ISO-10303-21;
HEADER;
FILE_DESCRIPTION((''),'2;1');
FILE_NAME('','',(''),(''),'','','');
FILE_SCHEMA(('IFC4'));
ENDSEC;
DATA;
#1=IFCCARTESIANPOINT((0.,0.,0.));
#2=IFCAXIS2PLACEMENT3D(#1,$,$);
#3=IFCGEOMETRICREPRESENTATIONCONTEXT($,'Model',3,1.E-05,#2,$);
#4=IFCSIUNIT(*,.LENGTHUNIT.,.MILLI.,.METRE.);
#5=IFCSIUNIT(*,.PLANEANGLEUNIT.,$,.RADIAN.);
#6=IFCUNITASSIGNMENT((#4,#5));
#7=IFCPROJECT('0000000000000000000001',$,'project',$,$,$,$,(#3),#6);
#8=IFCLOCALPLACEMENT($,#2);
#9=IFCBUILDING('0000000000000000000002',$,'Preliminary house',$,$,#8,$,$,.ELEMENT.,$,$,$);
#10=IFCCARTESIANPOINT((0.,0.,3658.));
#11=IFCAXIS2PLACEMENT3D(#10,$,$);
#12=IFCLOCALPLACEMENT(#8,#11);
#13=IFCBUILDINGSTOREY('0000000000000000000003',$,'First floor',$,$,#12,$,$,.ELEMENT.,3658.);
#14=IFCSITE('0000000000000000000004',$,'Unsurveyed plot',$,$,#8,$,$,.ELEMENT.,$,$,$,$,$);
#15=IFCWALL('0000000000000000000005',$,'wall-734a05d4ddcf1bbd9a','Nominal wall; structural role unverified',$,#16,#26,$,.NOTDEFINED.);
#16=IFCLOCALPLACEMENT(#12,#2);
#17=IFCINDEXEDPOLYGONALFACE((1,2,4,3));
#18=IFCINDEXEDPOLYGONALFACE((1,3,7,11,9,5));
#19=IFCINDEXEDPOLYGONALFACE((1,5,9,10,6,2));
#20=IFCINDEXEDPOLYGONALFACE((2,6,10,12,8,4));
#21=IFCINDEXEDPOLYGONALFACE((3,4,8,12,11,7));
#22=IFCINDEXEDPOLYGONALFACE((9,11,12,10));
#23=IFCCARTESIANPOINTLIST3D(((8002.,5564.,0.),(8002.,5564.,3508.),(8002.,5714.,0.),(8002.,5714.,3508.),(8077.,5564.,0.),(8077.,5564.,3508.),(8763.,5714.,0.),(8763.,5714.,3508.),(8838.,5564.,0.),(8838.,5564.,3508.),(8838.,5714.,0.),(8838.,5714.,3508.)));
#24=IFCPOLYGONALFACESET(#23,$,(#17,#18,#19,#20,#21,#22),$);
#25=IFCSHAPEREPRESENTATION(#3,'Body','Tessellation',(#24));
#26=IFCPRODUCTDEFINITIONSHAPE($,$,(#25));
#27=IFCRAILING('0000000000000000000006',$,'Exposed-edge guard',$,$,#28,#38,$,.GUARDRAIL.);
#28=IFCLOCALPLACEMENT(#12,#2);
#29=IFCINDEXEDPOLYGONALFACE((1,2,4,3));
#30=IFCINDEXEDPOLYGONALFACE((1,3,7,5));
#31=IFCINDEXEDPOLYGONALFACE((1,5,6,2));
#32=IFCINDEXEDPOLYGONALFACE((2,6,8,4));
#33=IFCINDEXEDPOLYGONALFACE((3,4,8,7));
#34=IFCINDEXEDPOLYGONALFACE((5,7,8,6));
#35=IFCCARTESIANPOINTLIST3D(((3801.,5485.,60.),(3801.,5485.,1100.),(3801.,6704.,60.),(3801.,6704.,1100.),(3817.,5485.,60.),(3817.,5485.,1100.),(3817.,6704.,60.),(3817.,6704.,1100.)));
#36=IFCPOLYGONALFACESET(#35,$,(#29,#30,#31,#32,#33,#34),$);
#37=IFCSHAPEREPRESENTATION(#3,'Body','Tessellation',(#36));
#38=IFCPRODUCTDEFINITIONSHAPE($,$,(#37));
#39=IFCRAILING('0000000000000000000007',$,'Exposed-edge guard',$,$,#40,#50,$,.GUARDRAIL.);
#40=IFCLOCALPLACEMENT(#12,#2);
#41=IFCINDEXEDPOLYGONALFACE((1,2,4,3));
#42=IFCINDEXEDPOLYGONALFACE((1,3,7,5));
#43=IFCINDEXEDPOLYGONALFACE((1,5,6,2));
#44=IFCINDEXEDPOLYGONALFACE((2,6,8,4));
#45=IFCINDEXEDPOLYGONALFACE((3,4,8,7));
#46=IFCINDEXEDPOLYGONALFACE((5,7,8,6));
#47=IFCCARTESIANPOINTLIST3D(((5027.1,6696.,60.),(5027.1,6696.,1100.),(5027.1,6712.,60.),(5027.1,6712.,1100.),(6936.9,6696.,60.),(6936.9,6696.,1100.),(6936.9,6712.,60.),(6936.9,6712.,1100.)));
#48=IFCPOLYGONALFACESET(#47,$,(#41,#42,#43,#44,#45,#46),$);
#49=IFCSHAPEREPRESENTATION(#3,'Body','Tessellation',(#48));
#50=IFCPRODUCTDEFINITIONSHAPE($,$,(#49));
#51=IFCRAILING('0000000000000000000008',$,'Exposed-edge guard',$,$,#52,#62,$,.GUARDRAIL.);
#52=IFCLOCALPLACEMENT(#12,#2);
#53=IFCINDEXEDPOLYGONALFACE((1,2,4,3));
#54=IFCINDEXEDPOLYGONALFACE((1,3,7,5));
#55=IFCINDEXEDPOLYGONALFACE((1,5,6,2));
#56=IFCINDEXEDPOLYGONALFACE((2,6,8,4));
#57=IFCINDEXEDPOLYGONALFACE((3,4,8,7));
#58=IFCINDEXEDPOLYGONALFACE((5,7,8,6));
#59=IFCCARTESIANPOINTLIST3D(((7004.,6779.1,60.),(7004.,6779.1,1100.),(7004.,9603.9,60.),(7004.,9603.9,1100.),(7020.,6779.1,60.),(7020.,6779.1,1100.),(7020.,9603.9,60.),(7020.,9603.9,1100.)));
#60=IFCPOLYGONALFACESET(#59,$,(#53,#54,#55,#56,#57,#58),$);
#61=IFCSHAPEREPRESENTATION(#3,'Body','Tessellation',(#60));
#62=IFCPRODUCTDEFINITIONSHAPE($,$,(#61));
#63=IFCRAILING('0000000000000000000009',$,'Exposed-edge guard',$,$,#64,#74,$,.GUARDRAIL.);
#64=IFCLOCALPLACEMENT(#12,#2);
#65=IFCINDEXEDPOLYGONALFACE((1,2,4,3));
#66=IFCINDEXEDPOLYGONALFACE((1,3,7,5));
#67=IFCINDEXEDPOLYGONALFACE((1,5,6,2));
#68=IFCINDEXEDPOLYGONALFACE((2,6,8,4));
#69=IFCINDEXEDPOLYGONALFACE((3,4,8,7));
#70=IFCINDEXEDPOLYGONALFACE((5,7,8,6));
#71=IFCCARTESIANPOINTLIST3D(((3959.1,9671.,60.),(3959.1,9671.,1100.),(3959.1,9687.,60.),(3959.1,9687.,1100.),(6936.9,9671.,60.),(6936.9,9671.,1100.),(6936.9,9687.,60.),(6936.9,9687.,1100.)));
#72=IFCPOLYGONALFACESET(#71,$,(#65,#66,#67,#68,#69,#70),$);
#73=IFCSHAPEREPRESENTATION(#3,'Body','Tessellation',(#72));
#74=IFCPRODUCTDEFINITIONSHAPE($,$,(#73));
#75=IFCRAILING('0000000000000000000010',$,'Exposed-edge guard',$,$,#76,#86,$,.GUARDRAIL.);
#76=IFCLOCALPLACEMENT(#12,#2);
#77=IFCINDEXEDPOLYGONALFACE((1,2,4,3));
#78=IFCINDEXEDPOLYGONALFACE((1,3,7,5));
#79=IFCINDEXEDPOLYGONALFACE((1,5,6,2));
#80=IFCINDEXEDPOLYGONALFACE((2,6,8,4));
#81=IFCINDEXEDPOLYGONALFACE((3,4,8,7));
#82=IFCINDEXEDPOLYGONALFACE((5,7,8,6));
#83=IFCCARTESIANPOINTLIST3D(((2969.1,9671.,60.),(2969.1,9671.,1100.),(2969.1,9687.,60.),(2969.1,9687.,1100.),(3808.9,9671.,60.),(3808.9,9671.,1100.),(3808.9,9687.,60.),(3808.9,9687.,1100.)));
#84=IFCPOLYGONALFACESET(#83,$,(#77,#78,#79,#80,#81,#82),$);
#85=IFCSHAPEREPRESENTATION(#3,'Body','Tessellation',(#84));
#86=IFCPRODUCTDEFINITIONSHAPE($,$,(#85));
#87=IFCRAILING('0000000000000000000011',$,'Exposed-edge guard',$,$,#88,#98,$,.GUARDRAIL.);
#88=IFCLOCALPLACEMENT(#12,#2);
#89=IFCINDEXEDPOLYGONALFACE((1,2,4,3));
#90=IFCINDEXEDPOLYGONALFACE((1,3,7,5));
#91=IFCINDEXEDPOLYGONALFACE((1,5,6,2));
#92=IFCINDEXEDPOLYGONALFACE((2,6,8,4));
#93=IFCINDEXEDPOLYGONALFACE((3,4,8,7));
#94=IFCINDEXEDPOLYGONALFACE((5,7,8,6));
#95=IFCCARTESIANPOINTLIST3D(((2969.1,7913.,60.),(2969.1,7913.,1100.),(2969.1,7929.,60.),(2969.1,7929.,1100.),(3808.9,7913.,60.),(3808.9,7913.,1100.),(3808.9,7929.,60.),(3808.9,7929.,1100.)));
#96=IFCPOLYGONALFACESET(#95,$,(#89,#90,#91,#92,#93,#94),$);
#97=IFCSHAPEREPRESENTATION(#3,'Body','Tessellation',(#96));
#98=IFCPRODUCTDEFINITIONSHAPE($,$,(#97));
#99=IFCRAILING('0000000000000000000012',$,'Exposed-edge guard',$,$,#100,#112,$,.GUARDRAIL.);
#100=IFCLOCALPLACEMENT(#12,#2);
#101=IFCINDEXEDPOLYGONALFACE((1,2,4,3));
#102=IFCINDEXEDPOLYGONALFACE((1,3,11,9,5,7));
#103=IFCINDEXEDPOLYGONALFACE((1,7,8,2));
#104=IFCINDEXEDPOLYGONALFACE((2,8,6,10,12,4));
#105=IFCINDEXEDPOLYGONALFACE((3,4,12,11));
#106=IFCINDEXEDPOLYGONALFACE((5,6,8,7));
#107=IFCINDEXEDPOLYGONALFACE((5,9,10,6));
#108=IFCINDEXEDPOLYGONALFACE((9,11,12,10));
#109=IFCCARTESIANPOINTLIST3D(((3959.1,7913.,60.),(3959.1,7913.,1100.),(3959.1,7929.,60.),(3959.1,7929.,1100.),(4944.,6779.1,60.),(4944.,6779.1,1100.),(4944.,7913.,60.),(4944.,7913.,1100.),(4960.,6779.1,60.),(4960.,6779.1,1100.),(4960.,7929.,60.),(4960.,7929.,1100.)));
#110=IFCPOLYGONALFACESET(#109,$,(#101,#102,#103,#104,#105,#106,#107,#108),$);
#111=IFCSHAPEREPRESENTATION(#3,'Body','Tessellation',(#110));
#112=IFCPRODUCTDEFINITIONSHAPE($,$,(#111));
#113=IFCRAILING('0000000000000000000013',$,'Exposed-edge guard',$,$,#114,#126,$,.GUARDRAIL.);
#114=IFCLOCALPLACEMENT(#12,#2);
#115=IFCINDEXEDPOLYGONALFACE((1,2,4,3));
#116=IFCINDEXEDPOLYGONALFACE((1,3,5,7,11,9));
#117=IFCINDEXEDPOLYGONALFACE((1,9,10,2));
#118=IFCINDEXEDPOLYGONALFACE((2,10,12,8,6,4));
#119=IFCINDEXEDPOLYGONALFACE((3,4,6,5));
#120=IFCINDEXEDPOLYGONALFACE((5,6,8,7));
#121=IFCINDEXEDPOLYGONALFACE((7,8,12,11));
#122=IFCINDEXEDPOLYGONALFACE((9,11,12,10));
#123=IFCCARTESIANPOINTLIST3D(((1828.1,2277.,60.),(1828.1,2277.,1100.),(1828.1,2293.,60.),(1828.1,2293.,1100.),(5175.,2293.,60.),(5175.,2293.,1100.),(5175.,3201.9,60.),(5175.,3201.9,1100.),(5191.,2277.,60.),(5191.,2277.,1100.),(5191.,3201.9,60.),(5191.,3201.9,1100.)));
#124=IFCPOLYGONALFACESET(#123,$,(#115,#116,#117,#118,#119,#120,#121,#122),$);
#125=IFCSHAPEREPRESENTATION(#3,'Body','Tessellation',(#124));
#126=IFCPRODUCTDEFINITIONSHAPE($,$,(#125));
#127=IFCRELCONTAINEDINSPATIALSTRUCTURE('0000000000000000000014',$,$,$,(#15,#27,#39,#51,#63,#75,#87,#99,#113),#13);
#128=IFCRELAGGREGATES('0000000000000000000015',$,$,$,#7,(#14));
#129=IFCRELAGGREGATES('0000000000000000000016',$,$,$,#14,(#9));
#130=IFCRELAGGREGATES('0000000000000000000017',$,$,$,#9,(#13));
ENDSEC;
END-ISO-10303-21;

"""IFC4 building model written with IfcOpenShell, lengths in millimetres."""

from ifc_helpers import new_model, si_unit, frame, origin, place, context, project, spatial, polyline, outline, extrude, element, save


model = new_model("IFC4")

# Units and contexts
model_context = context("Model", 3, precision=1e-05, world=origin())
ifc_project = project(units=[si_unit("LENGTHUNIT", "METRE", prefix="MILLI"), si_unit("PLANEANGLEUNIT", "RADIAN")], contexts=[model_context])

# Site, building, storey
placement_1 = place(None, origin())
site = spatial("IfcSite", under=ifc_project, at=placement_1, Name="Unsurveyed plot", CompositionType="ELEMENT")
building = spatial("IfcBuilding", under=site, at=placement_1, Name="Preliminary house", CompositionType="ELEMENT")
placement_2 = place(placement_1, frame((0.0, 0.0, 3658.0)))
storey = spatial("IfcBuildingStorey", under=building, at=placement_2, Name="First floor", CompositionType="ELEMENT", Elevation=3658.0)

# Wall
element("IfcWall", 1, at=placement_2, inside=storey, Name="wall-734a05d4ddcf1bbd9a", Description="Nominal wall; structural role unverified", PredefinedType="NOTDEFINED", context=model_context, shape_type="SweptSolid", body=[
    extrude(outline(polyline([(8763.0, 5714.0), (8838.0, 5714.0), (8838.0, 5564.0), (8077.0, 5564.0), (8002.0, 5564.0), (8002.0, 5714.0), (8763.0, 5714.0)])), origin(), (0.0, 0.0, 1.0), 3508.0),
])

# Railings
element("IfcRailing", 2, at=placement_2, inside=storey, Name="Exposed-edge guard", PredefinedType="GUARDRAIL", context=model_context, shape_type="SweptSolid", body=[
    extrude(outline(polyline([(3801.0, 6704.0), (3817.0, 6704.0), (3817.0, 5485.0), (3801.0, 5485.0), (3801.0, 6704.0)])), frame((0.0, 0.0, 60.0)), (0.0, 0.0, 1.0), 1040.0),
])
element("IfcRailing", 3, at=placement_2, inside=storey, Name="Exposed-edge guard", PredefinedType="GUARDRAIL", context=model_context, shape_type="SweptSolid", body=[
    extrude(outline(polyline([(6936.9, 6712.0), (6936.9, 6696.0), (5027.1, 6696.0), (5027.1, 6712.0), (6936.9, 6712.0)])), frame((0.0, 0.0, 60.0)), (0.0, 0.0, 1.0), 1040.0),
])
element("IfcRailing", 4, at=placement_2, inside=storey, Name="Exposed-edge guard", PredefinedType="GUARDRAIL", context=model_context, shape_type="SweptSolid", body=[
    extrude(outline(polyline([(7004.0, 9603.9), (7020.0, 9603.9), (7020.0, 6779.1), (7004.0, 6779.1), (7004.0, 9603.9)])), frame((0.0, 0.0, 60.0)), (0.0, 0.0, 1.0), 1040.0),
])
element("IfcRailing", 5, at=placement_2, inside=storey, Name="Exposed-edge guard", PredefinedType="GUARDRAIL", context=model_context, shape_type="SweptSolid", body=[
    extrude(outline(polyline([(3959.1, 9671.0), (3959.1, 9687.0), (6936.9, 9687.0), (6936.9, 9671.0), (3959.1, 9671.0)])), frame((0.0, 0.0, 60.0)), (0.0, 0.0, 1.0), 1040.0),
])
element("IfcRailing", 6, at=placement_2, inside=storey, Name="Exposed-edge guard", PredefinedType="GUARDRAIL", context=model_context, shape_type="SweptSolid", body=[
    extrude(outline(polyline([(2969.1, 9671.0), (2969.1, 9687.0), (3808.9, 9687.0), (3808.9, 9671.0), (2969.1, 9671.0)])), frame((0.0, 0.0, 60.0)), (0.0, 0.0, 1.0), 1040.0),
])
element("IfcRailing", 7, at=placement_2, inside=storey, Name="Exposed-edge guard", PredefinedType="GUARDRAIL", context=model_context, shape_type="SweptSolid", body=[
    extrude(outline(polyline([(3808.9, 7929.0), (3808.9, 7913.0), (2969.1, 7913.0), (2969.1, 7929.0), (3808.9, 7929.0)])), frame((0.0, 0.0, 60.0)), (0.0, 0.0, 1.0), 1040.0),
])
element("IfcRailing", 8, at=placement_2, inside=storey, Name="Exposed-edge guard", PredefinedType="GUARDRAIL", context=model_context, shape_type="SweptSolid", body=[
    extrude(outline(polyline([(4960.0, 7929.0), (4960.0, 6779.1), (4944.0, 6779.1), (4944.0, 7913.0), (3959.1, 7913.0), (3959.1, 7929.0), (4960.0, 7929.0)])), frame((0.0, 0.0, 60.0)), (0.0, 0.0, 1.0), 1040.0),
])
element("IfcRailing", 9, at=placement_2, inside=storey, Name="Exposed-edge guard", PredefinedType="GUARDRAIL", context=model_context, shape_type="SweptSolid", body=[
    extrude(outline(polyline([(5175.0, 2293.0), (5175.0, 3201.9), (5191.0, 3201.9), (5191.0, 2277.0), (1828.1, 2277.0), (1828.1, 2293.0), (5175.0, 2293.0)])), frame((0.0, 0.0, 60.0)), (0.0, 0.0, 1.0), 1040.0),
])

save(model, "model.ifc")
